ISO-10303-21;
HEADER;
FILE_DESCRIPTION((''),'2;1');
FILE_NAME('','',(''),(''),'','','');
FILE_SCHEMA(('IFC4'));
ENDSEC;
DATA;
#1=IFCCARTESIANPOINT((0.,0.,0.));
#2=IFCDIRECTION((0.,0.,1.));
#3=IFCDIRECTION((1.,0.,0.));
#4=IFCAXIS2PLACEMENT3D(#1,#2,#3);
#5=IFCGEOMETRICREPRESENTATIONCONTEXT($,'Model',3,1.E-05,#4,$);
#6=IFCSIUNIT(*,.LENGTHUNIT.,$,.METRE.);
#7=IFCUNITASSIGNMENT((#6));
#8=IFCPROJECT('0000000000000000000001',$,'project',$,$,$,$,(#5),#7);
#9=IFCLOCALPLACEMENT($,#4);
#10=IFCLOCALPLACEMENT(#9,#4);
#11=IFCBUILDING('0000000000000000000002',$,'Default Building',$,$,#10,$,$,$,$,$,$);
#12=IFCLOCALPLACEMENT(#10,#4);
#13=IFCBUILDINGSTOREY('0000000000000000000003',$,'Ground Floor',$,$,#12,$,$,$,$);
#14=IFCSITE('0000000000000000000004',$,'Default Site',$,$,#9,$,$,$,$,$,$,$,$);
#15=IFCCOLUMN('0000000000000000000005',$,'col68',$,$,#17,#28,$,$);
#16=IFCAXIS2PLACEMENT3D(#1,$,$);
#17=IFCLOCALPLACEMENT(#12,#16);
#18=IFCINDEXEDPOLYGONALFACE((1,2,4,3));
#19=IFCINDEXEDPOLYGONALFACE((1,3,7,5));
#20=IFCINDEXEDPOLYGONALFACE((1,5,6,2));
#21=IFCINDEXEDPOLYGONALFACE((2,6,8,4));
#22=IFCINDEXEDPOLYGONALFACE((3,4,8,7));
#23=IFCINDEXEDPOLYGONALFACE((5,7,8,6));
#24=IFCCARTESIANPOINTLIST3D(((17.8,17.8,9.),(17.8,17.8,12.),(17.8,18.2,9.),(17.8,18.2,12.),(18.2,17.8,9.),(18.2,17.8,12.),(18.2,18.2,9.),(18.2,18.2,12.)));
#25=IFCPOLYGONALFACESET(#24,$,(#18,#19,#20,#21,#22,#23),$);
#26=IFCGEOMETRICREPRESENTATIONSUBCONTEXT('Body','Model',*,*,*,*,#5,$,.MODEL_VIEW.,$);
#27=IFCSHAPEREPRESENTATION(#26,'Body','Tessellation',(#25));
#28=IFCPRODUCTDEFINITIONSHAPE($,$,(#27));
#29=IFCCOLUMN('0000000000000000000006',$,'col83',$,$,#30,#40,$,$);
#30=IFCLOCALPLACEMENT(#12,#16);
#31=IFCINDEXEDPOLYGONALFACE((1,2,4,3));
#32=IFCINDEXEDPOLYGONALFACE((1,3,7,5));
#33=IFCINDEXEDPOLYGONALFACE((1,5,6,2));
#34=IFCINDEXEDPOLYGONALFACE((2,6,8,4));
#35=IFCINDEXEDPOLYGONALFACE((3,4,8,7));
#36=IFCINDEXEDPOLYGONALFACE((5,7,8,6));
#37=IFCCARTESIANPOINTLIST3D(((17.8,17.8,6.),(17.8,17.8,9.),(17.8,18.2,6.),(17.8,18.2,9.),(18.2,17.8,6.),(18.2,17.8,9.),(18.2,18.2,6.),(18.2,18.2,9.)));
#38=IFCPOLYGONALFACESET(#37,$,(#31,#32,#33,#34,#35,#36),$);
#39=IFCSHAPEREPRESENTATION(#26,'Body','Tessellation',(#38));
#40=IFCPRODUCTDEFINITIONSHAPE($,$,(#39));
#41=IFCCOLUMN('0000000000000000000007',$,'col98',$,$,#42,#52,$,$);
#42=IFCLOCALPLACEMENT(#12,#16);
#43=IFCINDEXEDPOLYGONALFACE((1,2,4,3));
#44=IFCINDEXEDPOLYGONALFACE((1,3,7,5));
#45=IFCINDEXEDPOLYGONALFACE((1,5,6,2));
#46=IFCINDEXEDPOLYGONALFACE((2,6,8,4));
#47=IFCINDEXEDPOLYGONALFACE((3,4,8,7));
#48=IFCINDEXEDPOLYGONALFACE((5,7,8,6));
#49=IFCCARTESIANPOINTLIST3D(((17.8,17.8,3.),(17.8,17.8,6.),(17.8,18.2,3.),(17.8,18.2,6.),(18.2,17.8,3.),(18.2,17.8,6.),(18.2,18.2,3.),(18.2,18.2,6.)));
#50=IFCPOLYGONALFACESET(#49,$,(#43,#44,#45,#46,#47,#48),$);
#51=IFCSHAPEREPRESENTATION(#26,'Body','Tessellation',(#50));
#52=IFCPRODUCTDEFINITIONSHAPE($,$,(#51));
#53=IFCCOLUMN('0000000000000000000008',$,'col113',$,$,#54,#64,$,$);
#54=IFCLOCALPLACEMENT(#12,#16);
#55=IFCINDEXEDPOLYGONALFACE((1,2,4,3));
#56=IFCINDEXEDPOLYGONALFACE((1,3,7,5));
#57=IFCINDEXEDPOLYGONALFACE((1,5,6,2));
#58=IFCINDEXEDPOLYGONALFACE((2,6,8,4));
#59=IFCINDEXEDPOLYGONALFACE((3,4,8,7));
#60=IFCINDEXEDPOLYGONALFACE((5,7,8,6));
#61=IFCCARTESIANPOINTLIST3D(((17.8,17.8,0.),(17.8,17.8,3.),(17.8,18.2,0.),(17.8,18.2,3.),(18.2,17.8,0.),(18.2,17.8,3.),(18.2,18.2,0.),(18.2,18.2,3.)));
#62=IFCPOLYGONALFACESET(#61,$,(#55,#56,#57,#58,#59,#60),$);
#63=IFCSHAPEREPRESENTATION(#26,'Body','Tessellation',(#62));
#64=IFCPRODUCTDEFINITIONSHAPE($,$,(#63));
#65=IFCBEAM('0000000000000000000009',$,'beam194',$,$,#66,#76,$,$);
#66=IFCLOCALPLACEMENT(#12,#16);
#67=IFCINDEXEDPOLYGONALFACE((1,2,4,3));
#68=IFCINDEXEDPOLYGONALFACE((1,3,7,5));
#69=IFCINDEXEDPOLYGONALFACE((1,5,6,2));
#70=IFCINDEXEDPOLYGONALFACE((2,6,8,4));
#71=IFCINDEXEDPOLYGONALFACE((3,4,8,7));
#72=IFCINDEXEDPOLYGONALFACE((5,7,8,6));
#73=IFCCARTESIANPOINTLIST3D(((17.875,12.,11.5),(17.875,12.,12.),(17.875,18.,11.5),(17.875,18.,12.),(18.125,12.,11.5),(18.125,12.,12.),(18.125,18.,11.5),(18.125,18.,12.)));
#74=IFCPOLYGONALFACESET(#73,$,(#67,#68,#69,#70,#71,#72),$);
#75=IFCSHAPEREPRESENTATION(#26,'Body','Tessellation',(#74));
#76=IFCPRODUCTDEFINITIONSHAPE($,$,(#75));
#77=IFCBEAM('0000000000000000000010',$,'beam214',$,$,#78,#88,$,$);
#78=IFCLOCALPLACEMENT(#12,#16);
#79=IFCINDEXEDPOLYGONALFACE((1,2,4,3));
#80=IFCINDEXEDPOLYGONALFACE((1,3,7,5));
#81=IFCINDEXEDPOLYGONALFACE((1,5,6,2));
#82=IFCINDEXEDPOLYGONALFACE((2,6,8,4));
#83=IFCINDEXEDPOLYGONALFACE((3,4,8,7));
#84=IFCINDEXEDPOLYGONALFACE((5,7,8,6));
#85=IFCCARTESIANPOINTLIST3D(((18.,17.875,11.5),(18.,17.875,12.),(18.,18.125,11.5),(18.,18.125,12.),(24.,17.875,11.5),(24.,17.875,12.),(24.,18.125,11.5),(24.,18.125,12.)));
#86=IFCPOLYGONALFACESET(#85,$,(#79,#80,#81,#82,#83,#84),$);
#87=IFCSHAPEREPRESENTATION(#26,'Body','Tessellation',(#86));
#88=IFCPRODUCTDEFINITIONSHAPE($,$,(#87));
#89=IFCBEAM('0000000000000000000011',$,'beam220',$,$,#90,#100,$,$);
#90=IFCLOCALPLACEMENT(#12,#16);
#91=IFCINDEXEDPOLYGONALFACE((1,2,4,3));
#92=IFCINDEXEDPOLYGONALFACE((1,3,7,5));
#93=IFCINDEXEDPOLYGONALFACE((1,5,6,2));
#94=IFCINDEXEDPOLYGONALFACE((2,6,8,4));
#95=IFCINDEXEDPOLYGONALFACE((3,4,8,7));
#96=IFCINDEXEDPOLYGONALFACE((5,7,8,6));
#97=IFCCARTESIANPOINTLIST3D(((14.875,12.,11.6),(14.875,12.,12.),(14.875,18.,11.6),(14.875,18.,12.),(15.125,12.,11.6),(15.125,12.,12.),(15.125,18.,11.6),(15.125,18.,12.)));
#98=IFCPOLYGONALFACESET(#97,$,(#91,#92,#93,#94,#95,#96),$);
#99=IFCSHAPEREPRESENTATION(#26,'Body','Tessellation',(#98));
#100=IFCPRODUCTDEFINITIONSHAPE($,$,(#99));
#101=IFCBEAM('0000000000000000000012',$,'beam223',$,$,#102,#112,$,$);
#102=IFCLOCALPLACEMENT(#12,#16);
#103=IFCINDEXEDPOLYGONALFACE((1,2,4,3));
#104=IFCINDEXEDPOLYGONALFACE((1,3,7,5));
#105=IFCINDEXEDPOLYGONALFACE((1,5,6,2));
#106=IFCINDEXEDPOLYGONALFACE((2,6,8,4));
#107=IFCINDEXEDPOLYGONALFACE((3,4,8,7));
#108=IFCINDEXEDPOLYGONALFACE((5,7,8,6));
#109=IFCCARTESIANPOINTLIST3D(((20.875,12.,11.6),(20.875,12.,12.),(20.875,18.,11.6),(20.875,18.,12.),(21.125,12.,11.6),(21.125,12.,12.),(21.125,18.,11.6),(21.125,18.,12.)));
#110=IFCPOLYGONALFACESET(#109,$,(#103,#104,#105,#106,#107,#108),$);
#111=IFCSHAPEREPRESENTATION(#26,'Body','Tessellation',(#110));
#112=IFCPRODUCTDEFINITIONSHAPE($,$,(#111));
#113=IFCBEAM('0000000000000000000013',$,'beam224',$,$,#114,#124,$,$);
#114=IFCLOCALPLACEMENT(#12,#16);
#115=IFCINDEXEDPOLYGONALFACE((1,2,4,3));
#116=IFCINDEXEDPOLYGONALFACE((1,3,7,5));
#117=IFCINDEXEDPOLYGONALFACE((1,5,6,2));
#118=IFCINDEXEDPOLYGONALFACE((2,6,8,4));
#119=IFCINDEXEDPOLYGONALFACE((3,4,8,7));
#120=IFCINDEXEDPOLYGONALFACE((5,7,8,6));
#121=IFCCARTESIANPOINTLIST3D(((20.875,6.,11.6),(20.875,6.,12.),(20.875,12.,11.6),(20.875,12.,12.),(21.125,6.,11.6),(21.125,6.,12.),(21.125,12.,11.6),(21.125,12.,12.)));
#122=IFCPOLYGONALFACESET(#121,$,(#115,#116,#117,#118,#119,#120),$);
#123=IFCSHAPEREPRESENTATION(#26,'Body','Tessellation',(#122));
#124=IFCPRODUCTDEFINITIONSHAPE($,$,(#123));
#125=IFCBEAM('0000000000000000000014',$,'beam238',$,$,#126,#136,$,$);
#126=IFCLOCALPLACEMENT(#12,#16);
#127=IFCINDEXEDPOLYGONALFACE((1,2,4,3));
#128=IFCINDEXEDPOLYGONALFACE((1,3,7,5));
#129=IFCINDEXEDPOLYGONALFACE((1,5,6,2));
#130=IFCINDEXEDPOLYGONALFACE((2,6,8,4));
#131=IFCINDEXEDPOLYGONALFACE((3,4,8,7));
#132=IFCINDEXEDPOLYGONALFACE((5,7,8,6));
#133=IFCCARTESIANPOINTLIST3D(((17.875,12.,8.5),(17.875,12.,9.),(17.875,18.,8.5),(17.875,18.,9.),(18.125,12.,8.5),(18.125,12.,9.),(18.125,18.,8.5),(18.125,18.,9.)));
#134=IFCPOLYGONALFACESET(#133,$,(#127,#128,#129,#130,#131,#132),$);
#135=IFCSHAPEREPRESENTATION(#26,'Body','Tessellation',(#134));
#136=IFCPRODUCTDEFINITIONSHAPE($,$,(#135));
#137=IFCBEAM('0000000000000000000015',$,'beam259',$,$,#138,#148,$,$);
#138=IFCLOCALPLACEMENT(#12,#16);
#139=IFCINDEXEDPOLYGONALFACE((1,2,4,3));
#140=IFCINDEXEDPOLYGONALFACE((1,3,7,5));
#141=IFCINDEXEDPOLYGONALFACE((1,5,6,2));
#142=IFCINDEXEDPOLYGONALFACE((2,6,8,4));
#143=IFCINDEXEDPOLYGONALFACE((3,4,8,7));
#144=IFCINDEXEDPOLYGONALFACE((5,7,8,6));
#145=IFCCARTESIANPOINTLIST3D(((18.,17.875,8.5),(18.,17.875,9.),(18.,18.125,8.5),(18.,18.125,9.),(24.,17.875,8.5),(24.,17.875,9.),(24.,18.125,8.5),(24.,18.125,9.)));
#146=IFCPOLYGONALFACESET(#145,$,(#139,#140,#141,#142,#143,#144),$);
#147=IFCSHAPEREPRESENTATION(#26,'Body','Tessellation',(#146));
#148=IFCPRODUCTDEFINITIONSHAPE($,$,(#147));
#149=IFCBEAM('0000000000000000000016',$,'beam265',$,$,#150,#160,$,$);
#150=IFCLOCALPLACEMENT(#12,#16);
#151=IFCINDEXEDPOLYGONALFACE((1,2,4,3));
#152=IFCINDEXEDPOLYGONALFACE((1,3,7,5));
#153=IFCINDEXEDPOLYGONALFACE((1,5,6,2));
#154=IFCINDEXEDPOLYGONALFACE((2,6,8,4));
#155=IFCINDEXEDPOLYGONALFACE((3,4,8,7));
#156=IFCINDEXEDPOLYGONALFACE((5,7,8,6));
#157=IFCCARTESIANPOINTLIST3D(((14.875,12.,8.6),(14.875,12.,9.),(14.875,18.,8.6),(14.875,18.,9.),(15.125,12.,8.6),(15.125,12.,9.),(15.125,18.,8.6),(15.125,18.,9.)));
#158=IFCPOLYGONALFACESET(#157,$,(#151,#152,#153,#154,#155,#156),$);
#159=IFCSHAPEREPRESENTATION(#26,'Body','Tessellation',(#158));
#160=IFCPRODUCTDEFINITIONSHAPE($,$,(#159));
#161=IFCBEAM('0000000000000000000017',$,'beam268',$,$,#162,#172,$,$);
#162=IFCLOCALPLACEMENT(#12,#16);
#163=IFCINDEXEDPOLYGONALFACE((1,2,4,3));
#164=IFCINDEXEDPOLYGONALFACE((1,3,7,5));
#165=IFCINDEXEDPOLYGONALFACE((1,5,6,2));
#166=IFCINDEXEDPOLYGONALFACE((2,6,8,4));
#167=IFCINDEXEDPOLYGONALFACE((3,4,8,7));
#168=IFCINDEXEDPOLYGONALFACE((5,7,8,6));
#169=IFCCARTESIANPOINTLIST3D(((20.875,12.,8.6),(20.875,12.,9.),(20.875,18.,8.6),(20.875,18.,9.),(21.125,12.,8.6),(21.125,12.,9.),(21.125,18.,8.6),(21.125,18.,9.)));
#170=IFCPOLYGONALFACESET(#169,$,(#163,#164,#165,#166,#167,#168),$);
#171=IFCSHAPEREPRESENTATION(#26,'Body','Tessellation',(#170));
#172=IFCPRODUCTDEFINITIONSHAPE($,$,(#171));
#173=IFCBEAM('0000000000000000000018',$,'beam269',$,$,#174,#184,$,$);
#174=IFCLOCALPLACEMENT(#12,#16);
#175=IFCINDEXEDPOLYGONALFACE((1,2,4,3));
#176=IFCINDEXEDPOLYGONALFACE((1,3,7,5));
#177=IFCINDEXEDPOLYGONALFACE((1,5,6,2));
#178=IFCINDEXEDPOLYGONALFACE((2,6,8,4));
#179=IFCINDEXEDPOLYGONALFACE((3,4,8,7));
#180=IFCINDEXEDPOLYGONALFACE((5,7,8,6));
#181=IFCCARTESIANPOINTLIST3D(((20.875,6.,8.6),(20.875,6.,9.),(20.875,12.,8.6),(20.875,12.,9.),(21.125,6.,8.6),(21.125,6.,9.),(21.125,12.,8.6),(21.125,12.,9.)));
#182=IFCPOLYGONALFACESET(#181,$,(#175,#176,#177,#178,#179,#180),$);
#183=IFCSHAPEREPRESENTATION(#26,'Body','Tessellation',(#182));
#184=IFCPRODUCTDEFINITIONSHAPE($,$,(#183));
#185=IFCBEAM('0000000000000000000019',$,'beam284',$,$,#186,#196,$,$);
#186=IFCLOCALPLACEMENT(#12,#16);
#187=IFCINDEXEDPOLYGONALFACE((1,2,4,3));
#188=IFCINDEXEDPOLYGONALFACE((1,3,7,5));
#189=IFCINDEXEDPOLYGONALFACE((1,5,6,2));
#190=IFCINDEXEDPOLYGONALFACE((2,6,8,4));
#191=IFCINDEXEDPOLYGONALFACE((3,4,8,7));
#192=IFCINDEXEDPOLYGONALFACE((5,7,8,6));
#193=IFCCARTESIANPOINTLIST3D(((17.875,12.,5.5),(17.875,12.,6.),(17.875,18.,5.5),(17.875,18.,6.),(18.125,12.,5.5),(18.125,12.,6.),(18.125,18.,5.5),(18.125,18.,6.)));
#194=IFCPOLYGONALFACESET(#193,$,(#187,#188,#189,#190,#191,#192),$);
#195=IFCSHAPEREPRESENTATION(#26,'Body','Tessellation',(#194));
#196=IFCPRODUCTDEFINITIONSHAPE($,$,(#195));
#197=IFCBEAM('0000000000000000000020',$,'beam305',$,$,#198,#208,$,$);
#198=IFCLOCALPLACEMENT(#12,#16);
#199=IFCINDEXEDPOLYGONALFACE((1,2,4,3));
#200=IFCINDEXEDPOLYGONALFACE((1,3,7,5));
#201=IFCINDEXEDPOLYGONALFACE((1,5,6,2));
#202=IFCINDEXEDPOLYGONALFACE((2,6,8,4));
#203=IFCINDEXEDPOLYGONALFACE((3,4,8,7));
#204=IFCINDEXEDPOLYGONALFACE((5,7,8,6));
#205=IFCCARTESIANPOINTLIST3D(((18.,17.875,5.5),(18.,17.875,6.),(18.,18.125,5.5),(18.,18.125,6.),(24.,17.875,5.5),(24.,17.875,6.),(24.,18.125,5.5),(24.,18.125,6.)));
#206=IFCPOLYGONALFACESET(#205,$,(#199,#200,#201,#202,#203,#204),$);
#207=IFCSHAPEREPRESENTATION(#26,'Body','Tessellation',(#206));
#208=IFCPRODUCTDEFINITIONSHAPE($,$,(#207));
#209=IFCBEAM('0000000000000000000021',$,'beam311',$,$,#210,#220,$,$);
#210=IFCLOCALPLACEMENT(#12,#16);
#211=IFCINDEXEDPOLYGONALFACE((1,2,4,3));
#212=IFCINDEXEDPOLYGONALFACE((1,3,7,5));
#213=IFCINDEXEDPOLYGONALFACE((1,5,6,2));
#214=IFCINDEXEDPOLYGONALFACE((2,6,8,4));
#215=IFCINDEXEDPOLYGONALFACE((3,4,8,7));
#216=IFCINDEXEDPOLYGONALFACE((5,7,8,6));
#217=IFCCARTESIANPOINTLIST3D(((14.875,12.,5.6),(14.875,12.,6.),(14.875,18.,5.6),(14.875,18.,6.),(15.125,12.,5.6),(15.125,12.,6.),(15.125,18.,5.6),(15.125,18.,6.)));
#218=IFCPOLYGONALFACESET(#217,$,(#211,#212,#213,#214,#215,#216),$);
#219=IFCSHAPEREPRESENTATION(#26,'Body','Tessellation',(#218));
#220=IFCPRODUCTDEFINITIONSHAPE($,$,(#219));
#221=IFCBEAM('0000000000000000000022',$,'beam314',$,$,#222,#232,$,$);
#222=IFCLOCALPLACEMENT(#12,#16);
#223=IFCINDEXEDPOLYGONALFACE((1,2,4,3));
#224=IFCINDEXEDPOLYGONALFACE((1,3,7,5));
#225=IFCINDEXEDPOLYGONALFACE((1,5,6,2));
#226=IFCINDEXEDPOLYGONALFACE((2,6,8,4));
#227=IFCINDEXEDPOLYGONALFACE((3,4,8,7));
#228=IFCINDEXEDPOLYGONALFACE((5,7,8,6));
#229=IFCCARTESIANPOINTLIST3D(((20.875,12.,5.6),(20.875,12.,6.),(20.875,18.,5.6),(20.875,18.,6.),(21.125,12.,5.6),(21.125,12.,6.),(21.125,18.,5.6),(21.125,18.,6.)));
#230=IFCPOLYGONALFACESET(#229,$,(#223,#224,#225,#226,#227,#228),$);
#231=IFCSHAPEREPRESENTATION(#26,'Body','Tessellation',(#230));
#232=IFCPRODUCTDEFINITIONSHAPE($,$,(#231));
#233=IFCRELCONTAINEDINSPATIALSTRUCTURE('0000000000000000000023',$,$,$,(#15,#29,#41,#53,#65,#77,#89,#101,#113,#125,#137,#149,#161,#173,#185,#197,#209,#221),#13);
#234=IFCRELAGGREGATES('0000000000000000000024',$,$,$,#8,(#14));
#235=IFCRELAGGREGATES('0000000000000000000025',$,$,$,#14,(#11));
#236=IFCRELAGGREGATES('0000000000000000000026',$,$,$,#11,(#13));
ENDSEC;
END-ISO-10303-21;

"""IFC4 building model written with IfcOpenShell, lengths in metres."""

from ifc_helpers import new_model, si_unit, frame, origin_with_axes, place, context, subcontext, project, spatial, indexed_curve, outline, extrude, element, save


model = new_model("IFC4")

# Units and contexts
model_context = context("Model", 3, precision=1e-05, world=origin_with_axes())
body_context = subcontext(model_context, "Body", "Model", "MODEL_VIEW")
ifc_project = project(units=[si_unit("LENGTHUNIT", "METRE")], contexts=[model_context])

# Site, building, storey
site_placement = place(None, origin_with_axes())
site = spatial("IfcSite", under=ifc_project, at=site_placement, Name="Default Site")
building_placement = place(site_placement, origin_with_axes())
building = spatial("IfcBuilding", under=site, at=building_placement, Name="Default Building")
storey_placement = place(building_placement, origin_with_axes())
storey = spatial("IfcBuildingStorey", under=building, at=storey_placement, Name="Ground Floor")

# Columns
for number, where, z_axis, x_axis, name in (
    (1, (17.8, 17.8, 9.0), (0.0, 0.0, 1.0), (1.0, 0.0, 0.0), "col68"),
    (2, (17.8, 17.8, 6.0), (0.0, 0.0, 1.0), (1.0, 0.0, 0.0), "col83"),
    (3, (17.8, 17.8, 3.0), (0.0, 0.0, 1.0), (1.0, 0.0, 0.0), "col98"),
    (4, (17.8, 17.8, 0.0), (0.0, 0.0, 1.0), (1.0, 0.0, 0.0), "col113"),
):
    element("IfcColumn", number, at=place(storey_placement, frame(where, z_axis=z_axis, x_axis=x_axis)), inside=storey, Name=name, context=body_context, shape_type="SweptSolid", body=[
        extrude(outline(indexed_curve([(0.0, 0.0), (0.0, 0.4), (0.4, 0.4), (0.4, 0.0), (0.0, 0.0)], self_intersect=False)), origin_with_axes(), (0.0, 0.0, 1.0), 3.0),
    ])

# Beams
for number, where, z_axis, x_axis, name in (
    (5, (18.125, 12.0, 11.5), (0.0, 0.0, 1.0), (0.0, 1.0, 0.0), "beam194"),
    (6, (18.0, 17.875, 11.5), (0.0, 0.0, 1.0), (1.0, 0.0, 0.0), "beam214"),
):
    element("IfcBeam", number, at=place(storey_placement, frame(where, z_axis=z_axis, x_axis=x_axis)), inside=storey, Name=name, context=body_context, shape_type="SweptSolid", body=[
        extrude(outline(indexed_curve([(0.0, 0.0), (0.0, 0.25), (6.0, 0.25), (6.0, 0.0), (0.0, 0.0)], self_intersect=False)), origin_with_axes(), (0.0, 0.0, 1.0), 0.5),
    ])
for number, where, z_axis, x_axis, name in (
    (7, (14.875, 18.0, 11.6), (0.0, 0.0, 1.0), (0.0, -1.0, 0.0), "beam220"),
    (8, (20.875, 18.0, 11.6), (0.0, 0.0, 1.0), (0.0, -1.0, 0.0), "beam223"),
    (9, (20.875, 12.0, 11.6), (0.0, 0.0, 1.0), (0.0, -1.0, 0.0), "beam224"),
):
    element("IfcBeam", number, at=place(storey_placement, frame(where, z_axis=z_axis, x_axis=x_axis)), inside=storey, Name=name, context=body_context, shape_type="SweptSolid", body=[
        extrude(outline(indexed_curve([(0.0, 0.0), (0.0, 0.25), (6.0, 0.25), (6.0, 0.0), (0.0, 0.0)], self_intersect=False)), origin_with_axes(), (0.0, 0.0, 1.0), 0.4),
    ])
for number, where, z_axis, x_axis, name in (
    (10, (18.125, 12.0, 8.5), (0.0, 0.0, 1.0), (0.0, 1.0, 0.0), "beam238"),
    (11, (18.0, 17.875, 8.5), (0.0, 0.0, 1.0), (1.0, 0.0, 0.0), "beam259"),
):
    element("IfcBeam", number, at=place(storey_placement, frame(where, z_axis=z_axis, x_axis=x_axis)), inside=storey, Name=name, context=body_context, shape_type="SweptSolid", body=[
        extrude(outline(indexed_curve([(0.0, 0.0), (0.0, 0.25), (6.0, 0.25), (6.0, 0.0), (0.0, 0.0)], self_intersect=False)), origin_with_axes(), (0.0, 0.0, 1.0), 0.5),
    ])
for number, where, z_axis, x_axis, name in (
    (12, (14.875, 18.0, 8.6), (0.0, 0.0, 1.0), (0.0, -1.0, 0.0), "beam265"),
    (13, (20.875, 18.0, 8.6), (0.0, 0.0, 1.0), (0.0, -1.0, 0.0), "beam268"),
    (14, (20.875, 12.0, 8.6), (0.0, 0.0, 1.0), (0.0, -1.0, 0.0), "beam269"),
):
    element("IfcBeam", number, at=place(storey_placement, frame(where, z_axis=z_axis, x_axis=x_axis)), inside=storey, Name=name, context=body_context, shape_type="SweptSolid", body=[
        extrude(outline(indexed_curve([(0.0, 0.0), (0.0, 0.25), (6.0, 0.25), (6.0, 0.0), (0.0, 0.0)], self_intersect=False)), origin_with_axes(), (0.0, 0.0, 1.0), 0.4),
    ])
for number, where, z_axis, x_axis, name in (
    (15, (18.125, 12.0, 5.5), (0.0, 0.0, 1.0), (0.0, 1.0, 0.0), "beam284"),
    (16, (18.0, 17.875, 5.5), (0.0, 0.0, 1.0), (1.0, 0.0, 0.0), "beam305"),
):
    element("IfcBeam", number, at=place(storey_placement, frame(where, z_axis=z_axis, x_axis=x_axis)), inside=storey, Name=name, context=body_context, shape_type="SweptSolid", body=[
        extrude(outline(indexed_curve([(0.0, 0.0), (0.0, 0.25), (6.0, 0.25), (6.0, 0.0), (0.0, 0.0)], self_intersect=False)), origin_with_axes(), (0.0, 0.0, 1.0), 0.5),
    ])
for number, where, z_axis, x_axis, name in (
    (17, (14.875, 18.0, 5.6), (0.0, 0.0, 1.0), (0.0, -1.0, 0.0), "beam311"),
    (18, (20.875, 18.0, 5.6), (0.0, 0.0, 1.0), (0.0, -1.0, 0.0), "beam314"),
):
    element("IfcBeam", number, at=place(storey_placement, frame(where, z_axis=z_axis, x_axis=x_axis)), inside=storey, Name=name, context=body_context, shape_type="SweptSolid", body=[
        extrude(outline(indexed_curve([(0.0, 0.0), (0.0, 0.25), (6.0, 0.25), (6.0, 0.0), (0.0, 0.0)], self_intersect=False)), origin_with_axes(), (0.0, 0.0, 1.0), 0.4),
    ])

save(model, "model.ifc")
